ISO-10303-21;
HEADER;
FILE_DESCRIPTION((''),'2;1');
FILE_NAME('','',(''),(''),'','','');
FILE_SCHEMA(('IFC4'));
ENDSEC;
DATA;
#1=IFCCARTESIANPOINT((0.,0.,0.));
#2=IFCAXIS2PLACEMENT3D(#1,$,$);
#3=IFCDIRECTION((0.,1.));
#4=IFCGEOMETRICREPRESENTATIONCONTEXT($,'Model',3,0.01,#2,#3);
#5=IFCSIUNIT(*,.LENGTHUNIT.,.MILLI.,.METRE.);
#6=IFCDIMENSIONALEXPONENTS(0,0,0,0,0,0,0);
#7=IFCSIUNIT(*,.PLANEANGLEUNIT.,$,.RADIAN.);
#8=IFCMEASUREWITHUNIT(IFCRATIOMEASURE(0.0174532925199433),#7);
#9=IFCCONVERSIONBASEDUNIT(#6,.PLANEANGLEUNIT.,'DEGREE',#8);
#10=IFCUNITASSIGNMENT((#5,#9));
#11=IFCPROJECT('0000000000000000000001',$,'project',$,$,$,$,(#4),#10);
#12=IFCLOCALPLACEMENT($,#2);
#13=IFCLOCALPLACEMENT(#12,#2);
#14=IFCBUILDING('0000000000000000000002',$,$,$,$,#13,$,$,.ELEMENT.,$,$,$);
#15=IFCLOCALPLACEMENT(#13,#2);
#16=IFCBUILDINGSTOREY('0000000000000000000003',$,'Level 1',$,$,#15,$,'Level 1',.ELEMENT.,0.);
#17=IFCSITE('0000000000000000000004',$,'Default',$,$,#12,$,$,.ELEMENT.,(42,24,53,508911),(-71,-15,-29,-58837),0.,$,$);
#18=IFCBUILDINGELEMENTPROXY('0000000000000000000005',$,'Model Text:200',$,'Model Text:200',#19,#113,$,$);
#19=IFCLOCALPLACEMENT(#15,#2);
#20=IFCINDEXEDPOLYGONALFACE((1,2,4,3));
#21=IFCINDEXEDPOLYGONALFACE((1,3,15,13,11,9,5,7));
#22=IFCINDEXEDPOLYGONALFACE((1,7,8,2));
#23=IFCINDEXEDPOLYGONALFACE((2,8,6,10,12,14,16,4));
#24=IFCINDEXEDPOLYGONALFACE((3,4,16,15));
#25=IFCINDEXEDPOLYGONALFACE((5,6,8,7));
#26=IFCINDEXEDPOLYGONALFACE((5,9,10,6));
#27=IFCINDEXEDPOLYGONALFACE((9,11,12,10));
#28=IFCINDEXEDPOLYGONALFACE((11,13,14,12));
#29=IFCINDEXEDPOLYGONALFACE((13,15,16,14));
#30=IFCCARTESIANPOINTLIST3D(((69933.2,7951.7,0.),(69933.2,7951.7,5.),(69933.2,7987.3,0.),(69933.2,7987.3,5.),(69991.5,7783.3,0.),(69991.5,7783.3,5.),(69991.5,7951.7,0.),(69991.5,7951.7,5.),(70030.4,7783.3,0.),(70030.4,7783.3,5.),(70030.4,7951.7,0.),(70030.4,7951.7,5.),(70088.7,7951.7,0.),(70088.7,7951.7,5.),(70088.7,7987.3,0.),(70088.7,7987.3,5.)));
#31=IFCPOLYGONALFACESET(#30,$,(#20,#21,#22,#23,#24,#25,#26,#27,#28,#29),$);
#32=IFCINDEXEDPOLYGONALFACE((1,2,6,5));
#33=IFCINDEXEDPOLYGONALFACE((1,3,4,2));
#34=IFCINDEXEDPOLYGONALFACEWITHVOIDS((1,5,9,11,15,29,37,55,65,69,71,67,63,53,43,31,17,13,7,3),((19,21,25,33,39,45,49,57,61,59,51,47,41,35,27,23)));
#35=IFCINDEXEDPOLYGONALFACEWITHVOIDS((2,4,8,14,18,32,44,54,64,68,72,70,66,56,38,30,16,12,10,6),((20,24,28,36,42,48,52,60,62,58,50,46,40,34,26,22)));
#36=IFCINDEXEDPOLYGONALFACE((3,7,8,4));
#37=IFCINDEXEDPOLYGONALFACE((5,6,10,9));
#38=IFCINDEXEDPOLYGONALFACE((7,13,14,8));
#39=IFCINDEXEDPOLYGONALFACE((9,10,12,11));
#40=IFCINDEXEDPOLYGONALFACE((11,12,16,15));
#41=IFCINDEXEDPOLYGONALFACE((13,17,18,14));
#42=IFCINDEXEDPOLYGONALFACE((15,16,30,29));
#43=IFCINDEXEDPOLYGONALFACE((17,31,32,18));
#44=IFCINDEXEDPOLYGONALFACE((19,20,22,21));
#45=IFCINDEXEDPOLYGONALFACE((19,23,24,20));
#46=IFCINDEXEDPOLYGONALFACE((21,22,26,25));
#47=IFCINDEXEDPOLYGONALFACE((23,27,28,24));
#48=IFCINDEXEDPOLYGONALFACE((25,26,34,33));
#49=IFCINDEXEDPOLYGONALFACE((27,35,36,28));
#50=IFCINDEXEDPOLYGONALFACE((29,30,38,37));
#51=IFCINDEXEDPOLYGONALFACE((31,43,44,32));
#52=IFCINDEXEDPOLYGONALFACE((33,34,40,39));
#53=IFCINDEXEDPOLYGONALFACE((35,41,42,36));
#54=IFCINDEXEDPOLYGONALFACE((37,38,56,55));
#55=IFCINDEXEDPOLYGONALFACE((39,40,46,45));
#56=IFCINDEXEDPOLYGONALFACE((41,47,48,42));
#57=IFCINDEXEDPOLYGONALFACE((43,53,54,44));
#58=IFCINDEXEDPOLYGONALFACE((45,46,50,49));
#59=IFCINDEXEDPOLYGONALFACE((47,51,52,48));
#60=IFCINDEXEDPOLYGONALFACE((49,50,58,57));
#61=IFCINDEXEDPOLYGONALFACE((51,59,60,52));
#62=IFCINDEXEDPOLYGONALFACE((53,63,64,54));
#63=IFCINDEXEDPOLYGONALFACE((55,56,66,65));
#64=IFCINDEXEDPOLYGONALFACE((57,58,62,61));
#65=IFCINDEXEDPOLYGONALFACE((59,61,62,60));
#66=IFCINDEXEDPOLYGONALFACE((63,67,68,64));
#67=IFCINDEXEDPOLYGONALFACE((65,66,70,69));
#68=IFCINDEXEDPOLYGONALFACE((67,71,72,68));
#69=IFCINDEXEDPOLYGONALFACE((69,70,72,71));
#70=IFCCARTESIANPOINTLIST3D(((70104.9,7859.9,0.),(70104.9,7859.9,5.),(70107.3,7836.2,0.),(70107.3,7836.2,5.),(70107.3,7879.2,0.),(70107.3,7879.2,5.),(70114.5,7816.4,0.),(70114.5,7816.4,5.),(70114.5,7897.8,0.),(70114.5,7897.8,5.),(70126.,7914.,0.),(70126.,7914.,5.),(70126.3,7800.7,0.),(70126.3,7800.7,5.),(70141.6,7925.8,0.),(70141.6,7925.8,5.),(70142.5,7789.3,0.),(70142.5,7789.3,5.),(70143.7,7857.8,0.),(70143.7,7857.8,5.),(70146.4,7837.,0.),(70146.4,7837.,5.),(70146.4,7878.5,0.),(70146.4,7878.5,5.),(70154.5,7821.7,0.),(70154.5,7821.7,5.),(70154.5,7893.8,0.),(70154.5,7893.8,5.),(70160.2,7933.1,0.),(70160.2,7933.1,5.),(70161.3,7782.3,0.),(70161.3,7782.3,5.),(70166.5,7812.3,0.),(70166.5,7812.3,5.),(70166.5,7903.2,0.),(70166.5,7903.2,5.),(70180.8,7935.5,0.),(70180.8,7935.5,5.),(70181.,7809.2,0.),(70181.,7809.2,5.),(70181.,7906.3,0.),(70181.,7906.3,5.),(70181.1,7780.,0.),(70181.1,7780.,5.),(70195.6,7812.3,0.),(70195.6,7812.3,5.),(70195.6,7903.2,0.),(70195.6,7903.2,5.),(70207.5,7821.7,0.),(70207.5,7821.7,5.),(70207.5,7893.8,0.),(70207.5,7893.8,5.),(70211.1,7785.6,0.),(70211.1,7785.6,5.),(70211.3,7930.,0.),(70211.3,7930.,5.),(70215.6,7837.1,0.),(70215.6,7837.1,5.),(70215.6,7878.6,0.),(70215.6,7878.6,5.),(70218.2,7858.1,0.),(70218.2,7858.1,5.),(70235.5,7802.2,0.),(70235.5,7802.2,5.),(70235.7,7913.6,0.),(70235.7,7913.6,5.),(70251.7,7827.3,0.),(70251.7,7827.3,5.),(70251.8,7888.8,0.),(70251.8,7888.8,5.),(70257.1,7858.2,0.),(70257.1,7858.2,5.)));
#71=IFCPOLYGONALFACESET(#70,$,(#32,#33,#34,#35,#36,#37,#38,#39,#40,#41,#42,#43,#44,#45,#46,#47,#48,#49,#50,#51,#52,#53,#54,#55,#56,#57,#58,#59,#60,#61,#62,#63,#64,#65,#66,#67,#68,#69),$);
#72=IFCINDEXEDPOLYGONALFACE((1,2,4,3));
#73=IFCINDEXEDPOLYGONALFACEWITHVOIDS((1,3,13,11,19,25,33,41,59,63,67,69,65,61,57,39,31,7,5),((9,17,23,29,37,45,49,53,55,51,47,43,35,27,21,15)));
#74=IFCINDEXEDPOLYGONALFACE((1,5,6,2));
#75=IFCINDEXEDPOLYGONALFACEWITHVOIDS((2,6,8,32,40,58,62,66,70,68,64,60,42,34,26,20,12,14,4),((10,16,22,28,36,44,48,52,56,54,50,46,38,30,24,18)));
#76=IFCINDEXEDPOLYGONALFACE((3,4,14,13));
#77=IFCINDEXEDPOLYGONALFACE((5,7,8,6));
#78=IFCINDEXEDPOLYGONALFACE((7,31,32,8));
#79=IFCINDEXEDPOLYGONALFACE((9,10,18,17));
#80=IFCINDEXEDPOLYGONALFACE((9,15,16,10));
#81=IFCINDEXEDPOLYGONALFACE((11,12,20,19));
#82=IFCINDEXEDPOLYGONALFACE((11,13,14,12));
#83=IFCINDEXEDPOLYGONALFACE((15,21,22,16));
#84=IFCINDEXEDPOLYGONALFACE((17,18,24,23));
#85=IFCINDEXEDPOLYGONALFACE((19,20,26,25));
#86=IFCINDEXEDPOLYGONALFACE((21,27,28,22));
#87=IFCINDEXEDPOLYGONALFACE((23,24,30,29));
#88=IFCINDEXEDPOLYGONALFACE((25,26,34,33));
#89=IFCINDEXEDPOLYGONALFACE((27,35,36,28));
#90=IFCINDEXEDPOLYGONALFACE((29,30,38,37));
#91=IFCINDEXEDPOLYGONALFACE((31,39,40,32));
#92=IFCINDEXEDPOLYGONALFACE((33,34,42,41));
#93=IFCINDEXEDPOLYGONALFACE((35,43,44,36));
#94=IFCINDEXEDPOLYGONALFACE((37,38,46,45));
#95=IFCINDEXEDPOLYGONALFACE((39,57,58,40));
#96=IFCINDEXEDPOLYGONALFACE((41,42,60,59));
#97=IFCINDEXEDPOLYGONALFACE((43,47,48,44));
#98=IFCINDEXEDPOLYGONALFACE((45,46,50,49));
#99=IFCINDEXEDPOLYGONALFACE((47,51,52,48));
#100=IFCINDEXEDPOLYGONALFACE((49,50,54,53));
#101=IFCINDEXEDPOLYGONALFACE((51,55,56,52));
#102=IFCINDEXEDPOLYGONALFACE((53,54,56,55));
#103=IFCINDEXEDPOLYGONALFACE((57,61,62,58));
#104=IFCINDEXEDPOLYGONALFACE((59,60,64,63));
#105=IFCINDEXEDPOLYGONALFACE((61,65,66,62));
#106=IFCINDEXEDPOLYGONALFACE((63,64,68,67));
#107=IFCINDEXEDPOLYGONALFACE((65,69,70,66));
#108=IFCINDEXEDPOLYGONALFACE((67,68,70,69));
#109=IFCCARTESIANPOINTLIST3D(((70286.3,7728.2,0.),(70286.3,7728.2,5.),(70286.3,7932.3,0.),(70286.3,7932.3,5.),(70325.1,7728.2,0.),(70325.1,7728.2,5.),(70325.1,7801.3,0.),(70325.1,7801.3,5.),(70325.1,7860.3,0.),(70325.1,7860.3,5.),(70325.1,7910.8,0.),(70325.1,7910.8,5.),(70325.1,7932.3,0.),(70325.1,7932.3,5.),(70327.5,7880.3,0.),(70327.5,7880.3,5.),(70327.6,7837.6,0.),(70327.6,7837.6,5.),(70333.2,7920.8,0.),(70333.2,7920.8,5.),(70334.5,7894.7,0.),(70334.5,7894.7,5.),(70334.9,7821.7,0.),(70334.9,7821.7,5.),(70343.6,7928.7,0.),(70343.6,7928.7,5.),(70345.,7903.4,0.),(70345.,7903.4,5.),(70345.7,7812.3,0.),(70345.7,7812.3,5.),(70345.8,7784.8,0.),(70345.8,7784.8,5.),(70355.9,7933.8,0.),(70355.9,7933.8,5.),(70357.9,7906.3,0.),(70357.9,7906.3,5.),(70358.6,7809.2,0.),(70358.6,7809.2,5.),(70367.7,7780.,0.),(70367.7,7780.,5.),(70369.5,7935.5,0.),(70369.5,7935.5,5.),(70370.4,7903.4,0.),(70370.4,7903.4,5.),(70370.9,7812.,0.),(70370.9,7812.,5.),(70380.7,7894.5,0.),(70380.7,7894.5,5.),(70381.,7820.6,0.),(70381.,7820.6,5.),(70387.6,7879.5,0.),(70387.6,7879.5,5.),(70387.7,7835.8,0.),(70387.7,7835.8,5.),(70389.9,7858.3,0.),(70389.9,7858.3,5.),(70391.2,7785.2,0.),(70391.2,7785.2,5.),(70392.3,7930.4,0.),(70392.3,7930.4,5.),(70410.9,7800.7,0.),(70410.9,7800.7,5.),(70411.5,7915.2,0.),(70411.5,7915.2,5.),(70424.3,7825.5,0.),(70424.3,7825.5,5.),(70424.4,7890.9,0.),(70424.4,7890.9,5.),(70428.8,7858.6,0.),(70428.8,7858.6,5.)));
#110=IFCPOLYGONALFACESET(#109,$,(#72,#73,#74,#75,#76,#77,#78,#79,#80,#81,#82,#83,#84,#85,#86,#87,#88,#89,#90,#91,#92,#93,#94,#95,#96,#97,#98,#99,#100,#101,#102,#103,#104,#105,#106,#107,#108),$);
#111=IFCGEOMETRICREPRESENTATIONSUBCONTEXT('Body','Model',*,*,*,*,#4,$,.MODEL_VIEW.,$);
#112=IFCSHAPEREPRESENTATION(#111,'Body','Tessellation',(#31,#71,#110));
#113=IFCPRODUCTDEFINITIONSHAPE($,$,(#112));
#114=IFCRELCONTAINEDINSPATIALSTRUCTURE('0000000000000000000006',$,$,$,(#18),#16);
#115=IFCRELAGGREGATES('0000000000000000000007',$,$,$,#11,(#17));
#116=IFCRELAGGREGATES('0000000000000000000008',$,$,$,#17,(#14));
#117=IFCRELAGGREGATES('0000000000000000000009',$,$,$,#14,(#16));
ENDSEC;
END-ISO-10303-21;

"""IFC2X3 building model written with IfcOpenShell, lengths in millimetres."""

from ifc_helpers import new_model, entity, si_unit, converted_unit, direction, frame, origin, place, context, subcontext, project, spatial, polyline, outline, extrude, element, save


model = new_model("IFC2X3")

# Units and contexts
model_context = context("Model", 3, precision=0.01, world=origin(), true_north=direction((0.0, 1.0)))
body_context = subcontext(model_context, "Body", "Model", "MODEL_VIEW")
ifc_project = project(units=[si_unit("LENGTHUNIT", "METRE", prefix="MILLI"), converted_unit("PLANEANGLEUNIT", "DEGREE", entity("IfcRatioMeasure", 0.0174532925199433), si_unit("PLANEANGLEUNIT", "RADIAN"), dimensions=[0, 0, 0, 0, 0, 0, 0])], contexts=[model_context])

# Site, building, storey
site_placement = place(None, origin())
site = spatial("IfcSite", under=ifc_project, at=site_placement, Name="Default", CompositionType="ELEMENT", RefLatitude=(42, 24, 53, 508911), RefLongitude=(-71, -15, -29, -58837), RefElevation=0.0)
building_placement = place(site_placement, origin())
building = spatial("IfcBuilding", under=site, at=building_placement, CompositionType="ELEMENT")
storey_placement = place(building_placement, origin())
storey = spatial("IfcBuildingStorey", under=building, at=storey_placement, Name="Level 1", LongName="Level 1", CompositionType="ELEMENT", Elevation=0.0)

# Building element proxy
proxy_1_placement = place(storey_placement, origin())
element("IfcBuildingElementProxy", 1, at=proxy_1_placement, inside=storey, Name="Model Text:200", ObjectType="Model Text:200", context=body_context, shape_type="SweptSolid", body=[
    extrude(outline(polyline([(-19.4, -135.2), (19.4, -135.2), (19.4, 33.2), (77.7, 33.2), (77.7, 68.8), (-77.7, 68.8), (-77.7, 33.2), (-19.4, 33.2), (-19.4, -135.2)])), frame((70010.9, 7918.5, 0.0)), (0.0, 0.0, 1.0), 5.0),
    extrude(outline(polyline([(-8.8, -65.7), (15.1, -65.7), (35.5, -60.5), (52.3, -50.4), (65.3, -35.4), (74.1, -17.3), (78.4, 2.1), (75.9, 32.5), (61.8, 58.5), (38.4, 77.1), (8.3, 85.6), (-22.7, 83.3), (-49.0, 69.9), (-67.8, 47.3), (-76.3, 17.5), (-76.0, -3.3), (-70.7, -22.5), (-60.5, -39.2), (-45.5, -52.3), (-27.7, -61.4), (-8.8, -65.7)]), holes=[polyline([(-2.7, -27.2), (-23.1, -22.5), (-37.5, -12.9), (-45.7, 0.0), (-47.3, 14.8), (-42.7, 28.9), (-32.2, 39.9), (-16.3, 46.3), (4.5, 46.9), (25.1, 42.1), (39.6, 32.6), (47.7, 19.7), (49.4, 5.0), (44.8, -9.2), (34.2, -20.2), (18.2, -26.7), (-2.7, -27.2)])]), frame((70171.1, 7857.8, 0.0), z_axis=(0.0, 0.0, 1.0), x_axis=(0.100608, -0.994926, 0.0)), (0.0, 0.0, 1.0), 5.0),
    extrude(outline(polyline([(-73.1, -75.4), (130.9, -75.4), (130.9, -36.6), (57.8, -36.6), (74.3, -15.9), (79.1, 6.0), (73.9, 29.5), (58.4, 49.2), (33.6, 62.6), (0.5, 67.1), (-31.8, 62.8), (-56.1, 49.8), (-71.3, 30.7), (-76.4, 7.8), (-74.7, -5.8), (-69.6, -18.1), (-61.7, -28.5), (-51.7, -36.6), (-73.1, -36.6), (-73.1, -75.4)]), holes=[polyline([(-1.2, -36.6), (-21.2, -34.2), (-35.6, -27.2), (-44.3, -16.7), (-47.2, -3.8), (-44.3, 8.7), (-35.4, 19.0), (-20.4, 25.9), (0.8, 28.2), (23.3, 26.0), (38.5, 19.3), (47.1, 9.2), (49.9, -3.1), (46.8, -16.0), (37.4, -26.8), (21.5, -34.1), (-1.2, -36.6)])]), frame((70361.7, 7859.1, 0.0), z_axis=(0.0, 0.0, 1.0), x_axis=(0.0, -1.0, 0.0)), (0.0, 0.0, 1.0), 5.0),
])

save(model, "model.ifc")
